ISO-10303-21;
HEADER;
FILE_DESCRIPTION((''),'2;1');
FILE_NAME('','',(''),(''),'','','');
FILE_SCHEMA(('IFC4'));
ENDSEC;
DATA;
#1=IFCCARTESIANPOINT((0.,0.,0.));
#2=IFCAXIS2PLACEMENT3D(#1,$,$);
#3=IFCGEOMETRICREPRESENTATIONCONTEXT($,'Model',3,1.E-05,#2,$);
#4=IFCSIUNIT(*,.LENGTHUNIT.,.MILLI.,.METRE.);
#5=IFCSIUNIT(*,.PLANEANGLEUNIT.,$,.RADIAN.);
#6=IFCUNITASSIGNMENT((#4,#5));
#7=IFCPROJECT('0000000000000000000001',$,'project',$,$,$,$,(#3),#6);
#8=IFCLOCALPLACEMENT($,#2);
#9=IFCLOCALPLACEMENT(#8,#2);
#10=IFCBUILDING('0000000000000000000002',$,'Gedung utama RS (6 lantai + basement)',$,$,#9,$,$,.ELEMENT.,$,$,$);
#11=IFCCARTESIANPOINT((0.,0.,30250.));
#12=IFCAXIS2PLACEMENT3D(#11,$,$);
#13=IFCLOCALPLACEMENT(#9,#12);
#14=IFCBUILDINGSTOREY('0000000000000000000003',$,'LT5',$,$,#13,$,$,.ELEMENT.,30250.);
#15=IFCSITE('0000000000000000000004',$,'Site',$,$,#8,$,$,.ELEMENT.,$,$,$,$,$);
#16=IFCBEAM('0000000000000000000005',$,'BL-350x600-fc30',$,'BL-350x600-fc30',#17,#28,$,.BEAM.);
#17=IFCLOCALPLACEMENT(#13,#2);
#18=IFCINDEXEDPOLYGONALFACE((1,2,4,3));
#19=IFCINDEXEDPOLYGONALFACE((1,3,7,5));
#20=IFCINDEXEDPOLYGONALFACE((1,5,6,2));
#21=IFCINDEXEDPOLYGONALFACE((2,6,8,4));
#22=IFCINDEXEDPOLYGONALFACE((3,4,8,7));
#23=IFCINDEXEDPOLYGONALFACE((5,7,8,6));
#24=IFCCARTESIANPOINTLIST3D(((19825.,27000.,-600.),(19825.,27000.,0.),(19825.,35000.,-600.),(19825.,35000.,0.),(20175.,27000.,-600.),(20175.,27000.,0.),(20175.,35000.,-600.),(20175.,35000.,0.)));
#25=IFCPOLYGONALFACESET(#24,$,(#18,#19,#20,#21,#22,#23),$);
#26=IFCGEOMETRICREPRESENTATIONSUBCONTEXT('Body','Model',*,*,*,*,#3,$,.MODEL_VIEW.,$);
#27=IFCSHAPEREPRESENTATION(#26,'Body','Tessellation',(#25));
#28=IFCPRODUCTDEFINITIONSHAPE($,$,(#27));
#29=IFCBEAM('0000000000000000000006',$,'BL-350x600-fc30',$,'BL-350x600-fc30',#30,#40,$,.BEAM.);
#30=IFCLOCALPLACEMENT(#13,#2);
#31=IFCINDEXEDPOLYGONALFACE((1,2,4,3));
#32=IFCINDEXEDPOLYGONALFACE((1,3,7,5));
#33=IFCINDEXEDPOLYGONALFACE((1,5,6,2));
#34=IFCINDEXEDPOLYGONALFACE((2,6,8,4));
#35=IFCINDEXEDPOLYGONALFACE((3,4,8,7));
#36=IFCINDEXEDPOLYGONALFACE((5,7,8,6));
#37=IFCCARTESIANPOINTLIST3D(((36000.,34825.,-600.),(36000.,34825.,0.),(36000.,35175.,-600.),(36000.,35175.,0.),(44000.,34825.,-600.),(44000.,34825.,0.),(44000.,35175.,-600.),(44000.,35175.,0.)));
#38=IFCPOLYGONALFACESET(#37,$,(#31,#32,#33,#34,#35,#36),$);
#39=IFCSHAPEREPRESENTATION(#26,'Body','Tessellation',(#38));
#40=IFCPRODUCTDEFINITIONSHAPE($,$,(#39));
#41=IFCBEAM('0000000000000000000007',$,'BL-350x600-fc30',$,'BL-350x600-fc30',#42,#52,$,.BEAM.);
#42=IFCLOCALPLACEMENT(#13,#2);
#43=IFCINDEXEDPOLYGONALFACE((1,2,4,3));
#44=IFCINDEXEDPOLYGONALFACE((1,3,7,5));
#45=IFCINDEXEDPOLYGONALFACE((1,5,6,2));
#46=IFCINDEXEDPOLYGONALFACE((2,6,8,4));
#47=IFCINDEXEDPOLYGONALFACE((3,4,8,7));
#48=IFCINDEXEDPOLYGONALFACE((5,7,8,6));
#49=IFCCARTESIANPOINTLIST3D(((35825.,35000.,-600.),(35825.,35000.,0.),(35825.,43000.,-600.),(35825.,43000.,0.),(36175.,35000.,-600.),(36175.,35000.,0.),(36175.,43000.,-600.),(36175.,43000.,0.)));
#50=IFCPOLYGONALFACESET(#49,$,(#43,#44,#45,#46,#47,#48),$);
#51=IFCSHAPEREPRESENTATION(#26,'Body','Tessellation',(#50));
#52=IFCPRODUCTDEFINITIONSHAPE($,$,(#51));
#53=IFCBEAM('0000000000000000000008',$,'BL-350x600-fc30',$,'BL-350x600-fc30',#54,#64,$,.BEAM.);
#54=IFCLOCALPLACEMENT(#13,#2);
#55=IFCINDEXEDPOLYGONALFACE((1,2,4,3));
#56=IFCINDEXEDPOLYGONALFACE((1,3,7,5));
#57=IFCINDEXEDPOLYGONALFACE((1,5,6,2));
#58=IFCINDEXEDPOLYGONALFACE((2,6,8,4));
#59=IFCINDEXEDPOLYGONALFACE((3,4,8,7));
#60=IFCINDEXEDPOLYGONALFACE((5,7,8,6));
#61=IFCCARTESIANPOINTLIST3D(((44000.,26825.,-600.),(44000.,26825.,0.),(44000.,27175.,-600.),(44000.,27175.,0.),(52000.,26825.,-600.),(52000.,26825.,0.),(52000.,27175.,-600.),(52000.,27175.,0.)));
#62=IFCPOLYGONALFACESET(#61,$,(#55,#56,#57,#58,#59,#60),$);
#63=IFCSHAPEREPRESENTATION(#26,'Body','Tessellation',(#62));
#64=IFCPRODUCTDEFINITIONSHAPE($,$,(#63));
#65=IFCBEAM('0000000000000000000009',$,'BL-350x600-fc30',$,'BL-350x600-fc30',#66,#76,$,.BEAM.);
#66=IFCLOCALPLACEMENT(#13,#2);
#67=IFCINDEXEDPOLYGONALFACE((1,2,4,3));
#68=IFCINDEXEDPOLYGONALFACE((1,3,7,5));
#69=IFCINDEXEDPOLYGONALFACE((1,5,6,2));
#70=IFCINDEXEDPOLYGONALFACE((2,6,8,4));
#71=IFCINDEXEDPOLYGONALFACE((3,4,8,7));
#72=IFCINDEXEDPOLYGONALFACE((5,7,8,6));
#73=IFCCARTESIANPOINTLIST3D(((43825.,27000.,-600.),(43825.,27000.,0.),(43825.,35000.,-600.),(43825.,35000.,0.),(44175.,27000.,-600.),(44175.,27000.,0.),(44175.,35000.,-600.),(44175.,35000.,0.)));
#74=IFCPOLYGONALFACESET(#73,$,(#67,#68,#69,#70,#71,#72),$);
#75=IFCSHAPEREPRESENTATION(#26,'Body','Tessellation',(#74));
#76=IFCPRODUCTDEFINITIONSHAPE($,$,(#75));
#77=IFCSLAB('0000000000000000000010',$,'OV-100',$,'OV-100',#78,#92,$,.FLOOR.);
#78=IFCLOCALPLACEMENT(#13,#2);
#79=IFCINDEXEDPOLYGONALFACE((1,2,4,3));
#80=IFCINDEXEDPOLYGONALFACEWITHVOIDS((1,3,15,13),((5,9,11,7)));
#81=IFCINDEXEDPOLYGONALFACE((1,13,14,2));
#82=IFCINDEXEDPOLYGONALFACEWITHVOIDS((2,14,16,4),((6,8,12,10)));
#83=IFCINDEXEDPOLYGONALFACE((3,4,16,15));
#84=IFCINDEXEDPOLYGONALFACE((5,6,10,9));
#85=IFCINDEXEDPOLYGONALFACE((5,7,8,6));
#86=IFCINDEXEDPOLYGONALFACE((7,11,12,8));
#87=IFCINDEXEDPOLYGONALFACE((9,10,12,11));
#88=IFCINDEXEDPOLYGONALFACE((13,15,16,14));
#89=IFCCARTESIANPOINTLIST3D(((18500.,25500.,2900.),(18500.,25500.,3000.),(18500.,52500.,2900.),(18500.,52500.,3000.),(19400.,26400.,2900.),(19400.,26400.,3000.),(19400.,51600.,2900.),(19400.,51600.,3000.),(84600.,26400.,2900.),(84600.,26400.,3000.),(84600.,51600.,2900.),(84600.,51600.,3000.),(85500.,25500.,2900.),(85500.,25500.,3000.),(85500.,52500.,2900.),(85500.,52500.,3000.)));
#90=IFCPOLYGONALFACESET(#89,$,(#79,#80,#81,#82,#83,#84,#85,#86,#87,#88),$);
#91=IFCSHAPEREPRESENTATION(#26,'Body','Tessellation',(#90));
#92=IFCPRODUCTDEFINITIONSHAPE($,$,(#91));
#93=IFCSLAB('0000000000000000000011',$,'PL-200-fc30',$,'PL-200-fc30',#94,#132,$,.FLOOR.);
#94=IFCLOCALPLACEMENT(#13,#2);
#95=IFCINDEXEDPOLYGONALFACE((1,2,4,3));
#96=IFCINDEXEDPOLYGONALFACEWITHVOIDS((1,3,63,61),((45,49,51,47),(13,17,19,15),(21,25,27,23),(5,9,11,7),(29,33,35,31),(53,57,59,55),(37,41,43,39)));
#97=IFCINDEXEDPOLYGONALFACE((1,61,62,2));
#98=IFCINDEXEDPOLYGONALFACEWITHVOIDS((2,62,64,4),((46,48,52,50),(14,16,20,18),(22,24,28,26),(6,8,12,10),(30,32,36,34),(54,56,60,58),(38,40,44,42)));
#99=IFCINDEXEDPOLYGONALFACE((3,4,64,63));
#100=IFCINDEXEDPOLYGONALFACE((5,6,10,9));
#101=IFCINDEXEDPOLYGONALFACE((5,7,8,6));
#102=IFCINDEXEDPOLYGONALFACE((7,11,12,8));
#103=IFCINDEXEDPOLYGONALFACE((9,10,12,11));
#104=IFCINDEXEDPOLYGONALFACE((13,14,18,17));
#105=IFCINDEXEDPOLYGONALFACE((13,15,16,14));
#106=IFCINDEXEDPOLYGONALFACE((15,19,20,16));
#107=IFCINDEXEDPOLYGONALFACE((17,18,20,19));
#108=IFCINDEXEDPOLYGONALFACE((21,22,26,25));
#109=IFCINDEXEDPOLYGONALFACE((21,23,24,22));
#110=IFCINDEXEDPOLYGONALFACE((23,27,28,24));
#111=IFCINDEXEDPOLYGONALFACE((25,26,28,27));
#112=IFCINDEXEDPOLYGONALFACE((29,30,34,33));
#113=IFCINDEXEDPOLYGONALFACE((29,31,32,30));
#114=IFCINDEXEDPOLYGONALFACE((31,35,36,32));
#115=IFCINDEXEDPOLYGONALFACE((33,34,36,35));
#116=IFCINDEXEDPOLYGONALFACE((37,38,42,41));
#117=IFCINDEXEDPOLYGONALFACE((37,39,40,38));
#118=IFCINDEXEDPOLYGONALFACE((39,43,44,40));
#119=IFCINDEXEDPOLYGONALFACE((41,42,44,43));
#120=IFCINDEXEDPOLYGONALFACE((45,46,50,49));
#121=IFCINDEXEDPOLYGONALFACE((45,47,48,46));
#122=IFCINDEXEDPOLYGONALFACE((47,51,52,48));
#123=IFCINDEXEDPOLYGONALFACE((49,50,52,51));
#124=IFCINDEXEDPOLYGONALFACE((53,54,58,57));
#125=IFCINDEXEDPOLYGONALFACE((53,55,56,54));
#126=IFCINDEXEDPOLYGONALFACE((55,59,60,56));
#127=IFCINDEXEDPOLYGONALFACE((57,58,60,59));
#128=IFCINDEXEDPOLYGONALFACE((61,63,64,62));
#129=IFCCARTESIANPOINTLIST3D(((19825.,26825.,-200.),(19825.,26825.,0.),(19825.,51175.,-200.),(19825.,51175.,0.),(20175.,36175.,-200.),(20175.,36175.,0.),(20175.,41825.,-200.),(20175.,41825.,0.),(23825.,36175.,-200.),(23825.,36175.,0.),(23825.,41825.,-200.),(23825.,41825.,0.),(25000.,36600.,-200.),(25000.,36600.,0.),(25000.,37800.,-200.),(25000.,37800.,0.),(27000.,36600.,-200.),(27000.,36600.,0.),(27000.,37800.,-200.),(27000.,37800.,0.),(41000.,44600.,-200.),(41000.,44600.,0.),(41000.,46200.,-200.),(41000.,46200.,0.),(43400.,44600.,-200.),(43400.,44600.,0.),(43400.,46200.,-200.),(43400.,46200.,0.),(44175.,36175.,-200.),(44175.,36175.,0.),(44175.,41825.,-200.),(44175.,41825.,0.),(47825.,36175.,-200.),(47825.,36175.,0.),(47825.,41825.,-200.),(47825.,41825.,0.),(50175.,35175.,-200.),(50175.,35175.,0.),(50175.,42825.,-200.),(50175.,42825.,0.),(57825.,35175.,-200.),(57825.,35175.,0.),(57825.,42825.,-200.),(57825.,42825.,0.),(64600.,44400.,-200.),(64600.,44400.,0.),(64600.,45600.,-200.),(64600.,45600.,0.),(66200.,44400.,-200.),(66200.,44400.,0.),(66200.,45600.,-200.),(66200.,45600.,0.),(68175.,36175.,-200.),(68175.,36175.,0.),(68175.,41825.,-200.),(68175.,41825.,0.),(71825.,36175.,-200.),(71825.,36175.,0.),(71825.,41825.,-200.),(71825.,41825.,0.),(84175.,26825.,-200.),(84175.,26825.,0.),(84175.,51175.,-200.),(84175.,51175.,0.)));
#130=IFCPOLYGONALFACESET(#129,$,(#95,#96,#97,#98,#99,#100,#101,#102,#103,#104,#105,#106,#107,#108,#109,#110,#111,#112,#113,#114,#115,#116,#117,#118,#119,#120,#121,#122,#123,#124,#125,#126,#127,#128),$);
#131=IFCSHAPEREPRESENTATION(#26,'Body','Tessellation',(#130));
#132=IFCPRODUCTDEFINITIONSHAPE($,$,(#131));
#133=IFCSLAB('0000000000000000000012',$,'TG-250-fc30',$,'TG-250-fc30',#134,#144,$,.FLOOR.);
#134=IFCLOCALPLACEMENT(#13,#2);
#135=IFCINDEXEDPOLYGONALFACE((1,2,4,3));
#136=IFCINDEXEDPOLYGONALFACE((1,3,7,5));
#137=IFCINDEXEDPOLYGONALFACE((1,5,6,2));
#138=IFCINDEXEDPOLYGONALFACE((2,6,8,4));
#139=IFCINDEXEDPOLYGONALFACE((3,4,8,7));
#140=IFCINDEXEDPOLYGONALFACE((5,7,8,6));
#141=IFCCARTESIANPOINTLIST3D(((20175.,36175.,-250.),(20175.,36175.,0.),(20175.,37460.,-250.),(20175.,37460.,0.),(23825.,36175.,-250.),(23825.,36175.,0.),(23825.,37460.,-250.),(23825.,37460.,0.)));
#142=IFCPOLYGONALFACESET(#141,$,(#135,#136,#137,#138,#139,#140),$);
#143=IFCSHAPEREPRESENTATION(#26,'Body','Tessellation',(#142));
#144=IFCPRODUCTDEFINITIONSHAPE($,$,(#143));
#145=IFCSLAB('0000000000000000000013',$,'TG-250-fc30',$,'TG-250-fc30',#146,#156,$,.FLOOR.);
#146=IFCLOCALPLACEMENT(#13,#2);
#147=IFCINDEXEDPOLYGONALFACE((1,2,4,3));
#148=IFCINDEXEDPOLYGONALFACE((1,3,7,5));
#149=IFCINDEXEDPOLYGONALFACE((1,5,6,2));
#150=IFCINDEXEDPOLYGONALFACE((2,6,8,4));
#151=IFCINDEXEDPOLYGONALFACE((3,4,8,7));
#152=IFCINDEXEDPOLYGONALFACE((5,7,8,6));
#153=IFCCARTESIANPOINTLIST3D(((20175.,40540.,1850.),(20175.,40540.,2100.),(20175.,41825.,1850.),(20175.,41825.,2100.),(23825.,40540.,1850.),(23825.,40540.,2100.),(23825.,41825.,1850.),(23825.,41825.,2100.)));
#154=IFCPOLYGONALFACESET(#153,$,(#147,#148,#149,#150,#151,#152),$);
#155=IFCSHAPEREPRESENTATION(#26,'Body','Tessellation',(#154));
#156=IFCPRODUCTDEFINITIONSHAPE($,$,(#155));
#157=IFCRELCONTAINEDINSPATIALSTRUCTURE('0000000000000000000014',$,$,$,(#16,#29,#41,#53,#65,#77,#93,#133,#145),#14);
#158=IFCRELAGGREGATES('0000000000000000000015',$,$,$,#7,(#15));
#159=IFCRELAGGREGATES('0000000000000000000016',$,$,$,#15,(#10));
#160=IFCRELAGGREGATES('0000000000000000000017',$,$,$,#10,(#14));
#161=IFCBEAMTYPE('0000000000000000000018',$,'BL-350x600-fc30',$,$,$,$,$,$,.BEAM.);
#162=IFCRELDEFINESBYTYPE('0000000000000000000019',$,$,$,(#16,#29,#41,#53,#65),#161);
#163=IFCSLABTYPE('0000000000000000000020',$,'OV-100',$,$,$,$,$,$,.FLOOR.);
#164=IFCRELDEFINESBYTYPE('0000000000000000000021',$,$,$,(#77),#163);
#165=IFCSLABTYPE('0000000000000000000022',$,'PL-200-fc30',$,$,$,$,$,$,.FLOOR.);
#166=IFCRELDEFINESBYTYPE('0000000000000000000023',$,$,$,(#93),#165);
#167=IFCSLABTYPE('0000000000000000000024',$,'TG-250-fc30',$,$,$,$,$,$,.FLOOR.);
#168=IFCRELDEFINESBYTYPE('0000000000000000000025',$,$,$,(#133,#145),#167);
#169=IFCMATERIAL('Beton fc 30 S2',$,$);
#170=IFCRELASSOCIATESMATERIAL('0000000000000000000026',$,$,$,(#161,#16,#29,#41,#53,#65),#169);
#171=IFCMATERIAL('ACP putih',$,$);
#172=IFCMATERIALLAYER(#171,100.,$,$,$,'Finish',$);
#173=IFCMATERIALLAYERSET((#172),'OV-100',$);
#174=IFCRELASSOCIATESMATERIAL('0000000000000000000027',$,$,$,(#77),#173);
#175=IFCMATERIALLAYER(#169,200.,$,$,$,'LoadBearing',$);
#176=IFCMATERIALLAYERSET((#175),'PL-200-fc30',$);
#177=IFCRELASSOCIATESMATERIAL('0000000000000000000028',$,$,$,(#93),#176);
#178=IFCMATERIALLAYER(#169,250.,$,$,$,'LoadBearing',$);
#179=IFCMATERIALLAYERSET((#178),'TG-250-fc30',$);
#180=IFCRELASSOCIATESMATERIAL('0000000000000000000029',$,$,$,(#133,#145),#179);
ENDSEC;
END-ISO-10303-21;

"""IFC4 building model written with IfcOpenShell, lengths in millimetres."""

from ifc_helpers import new_model, si_unit, frame, origin, origin_2d, place, context, subcontext, project, spatial, polyline, rectangle, outline, extrude, material, layer, layer_set, layer_usage, material_profile, profile_set, profile_usage, type_object, element, save


model = new_model("IFC4")

# Units and contexts
model_context = context("Model", 3, precision=1e-05, world=origin())
body_context = subcontext(model_context, "Body", "Model", "MODEL_VIEW")
ifc_project = project(units=[si_unit("LENGTHUNIT", "METRE", prefix="MILLI"), si_unit("PLANEANGLEUNIT", "RADIAN")], contexts=[model_context])

# Site, building, storey
site_placement = place(None, origin())
site = spatial("IfcSite", under=ifc_project, at=site_placement, Name="Site", CompositionType="ELEMENT")
building_placement = place(site_placement, origin())
building = spatial("IfcBuilding", under=site, at=building_placement, Name="Gedung utama RS (6 lantai + basement)", CompositionType="ELEMENT")
storey_placement = place(building_placement, frame((0.0, 0.0, 30250.0)))
storey = spatial("IfcBuildingStorey", under=building, at=storey_placement, Name="LT5", CompositionType="ELEMENT", Elevation=30250.0)

# Beams
ifc_material_1 = material(Name="Beton fc 30 S2")
ifc_material_profile_1 = material_profile(ifc_material_1, rectangle(XDim=350.0, YDim=600.0, at=origin_2d()), Name="BL-350x600-fc30")
ifc_profile_set_1 = profile_set([ifc_material_profile_1], Name="BL-350x600-fc30")
ifc_profile_usage_1 = profile_usage(ifc_profile_set_1, cardinal=8)
beam_type = type_object("IfcBeamType", Name="BL-350x600-fc30", PredefinedType="BEAM", material=ifc_profile_set_1)
beam_1_placement = place(storey_placement, frame((20000.0, 27000.0, -300.0)))
element("IfcBeam", 1, at=beam_1_placement, inside=storey, type_object=beam_type, material=ifc_profile_usage_1, Name="BL-350x600-fc30", ObjectType="BL-350x600-fc30", PredefinedType="BEAM", context=body_context, shape_type="SweptSolid", body=[
    extrude(rectangle(XDim=350.0, YDim=600.0, at=origin_2d()), frame((0.0, 0.0, 0.0), z_axis=(0.0, 1.0, 0.0), x_axis=(-1.0, 0.0, 0.0)), (0.0, 0.0, 1.0), 8000.0),
])
beam_2_placement = place(storey_placement, frame((36000.0, 35000.0, -300.0)))
element("IfcBeam", 2, at=beam_2_placement, inside=storey, type_object=beam_type, material=ifc_profile_usage_1, Name="BL-350x600-fc30", ObjectType="BL-350x600-fc30", PredefinedType="BEAM", context=body_context, shape_type="SweptSolid", body=[
    extrude(rectangle(XDim=350.0, YDim=600.0, at=origin_2d()), frame((0.0, 0.0, 0.0), z_axis=(1.0, 0.0, 0.0), x_axis=(0.0, 1.0, 0.0)), (0.0, 0.0, 1.0), 8000.0),
])
beam_3_placement = place(storey_placement, frame((36000.0, 35000.0, -300.0)))
element("IfcBeam", 3, at=beam_3_placement, inside=storey, type_object=beam_type, material=ifc_profile_usage_1, Name="BL-350x600-fc30", ObjectType="BL-350x600-fc30", PredefinedType="BEAM", context=body_context, shape_type="SweptSolid", body=[
    extrude(rectangle(XDim=350.0, YDim=600.0, at=origin_2d()), frame((0.0, 0.0, 0.0), z_axis=(0.0, 1.0, 0.0), x_axis=(-1.0, 0.0, 0.0)), (0.0, 0.0, 1.0), 8000.0),
])
beam_4_placement = place(storey_placement, frame((44000.0, 27000.0, -300.0)))
element("IfcBeam", 4, at=beam_4_placement, inside=storey, type_object=beam_type, material=ifc_profile_usage_1, Name="BL-350x600-fc30", ObjectType="BL-350x600-fc30", PredefinedType="BEAM", context=body_context, shape_type="SweptSolid", body=[
    extrude(rectangle(XDim=350.0, YDim=600.0, at=origin_2d()), frame((0.0, 0.0, 0.0), z_axis=(1.0, 0.0, 0.0), x_axis=(0.0, 1.0, 0.0)), (0.0, 0.0, 1.0), 8000.0),
])
beam_5_placement = place(storey_placement, frame((44000.0, 27000.0, -300.0)))
element("IfcBeam", 5, at=beam_5_placement, inside=storey, type_object=beam_type, material=ifc_profile_usage_1, Name="BL-350x600-fc30", ObjectType="BL-350x600-fc30", PredefinedType="BEAM", context=body_context, shape_type="SweptSolid", body=[
    extrude(rectangle(XDim=350.0, YDim=600.0, at=origin_2d()), frame((0.0, 0.0, 0.0), z_axis=(0.0, 1.0, 0.0), x_axis=(-1.0, 0.0, 0.0)), (0.0, 0.0, 1.0), 8000.0),
])

# Slab
ifc_material_2 = material(Name="ACP putih")
ifc_layer_1 = layer(ifc_material_2, 100.0, Category="Finish")
ifc_layer_set_1 = layer_set([ifc_layer_1], Name="OV-100")
ifc_layer_usage_1 = layer_usage(ifc_layer_set_1, "AXIS3", "NEGATIVE", 3000.0)
slab_type_1 = type_object("IfcSlabType", Name="OV-100", PredefinedType="FLOOR")
slab_1_placement = place(storey_placement, origin())
element("IfcSlab", 6, at=slab_1_placement, inside=storey, type_object=slab_type_1, material=ifc_layer_usage_1, Name="OV-100", ObjectType="OV-100", PredefinedType="FLOOR", context=body_context, shape_type="SweptSolid", body=[
    extrude(outline(polyline([(85500.0, 52500.0), (18500.0, 52500.0), (18500.0, 25500.0), (85500.0, 25500.0), (85500.0, 52500.0)]), holes=[polyline([(84600.0, 26400.0), (19400.0, 26400.0), (19400.0, 51600.0), (84600.0, 51600.0), (84600.0, 26400.0)])]), frame((0.0, 0.0, 2900.0)), (0.0, 0.0, 1.0), 100.0),
])

# Slab, openings
ifc_layer_2 = layer(ifc_material_1, 200.0, Category="LoadBearing")
ifc_layer_set_2 = layer_set([ifc_layer_2], Name="PL-200-fc30")
ifc_layer_usage_2 = layer_usage(ifc_layer_set_2, "AXIS3", "NEGATIVE", 0.0)
slab_type_2 = type_object("IfcSlabType", Name="PL-200-fc30", PredefinedType="FLOOR")
slab_2_placement = place(storey_placement, origin())
slab_2 = element("IfcSlab", 7, at=slab_2_placement, inside=storey, type_object=slab_type_2, material=ifc_layer_usage_2, Name="PL-200-fc30", ObjectType="PL-200-fc30", PredefinedType="FLOOR", context=body_context, shape_type="SweptSolid", body=[
    extrude(outline(polyline([(84175.0, 51175.0), (19825.0, 51175.0), (19825.0, 26825.0), (84175.0, 26825.0), (84175.0, 51175.0)]), holes=[polyline([(23825.0, 36175.0), (23825.0, 41825.0), (20175.0, 41825.0), (20175.0, 36175.0), (23825.0, 36175.0)]), polyline([(47825.0, 36175.0), (47825.0, 41825.0), (44175.0, 41825.0), (44175.0, 36175.0), (47825.0, 36175.0)]), polyline([(71825.0, 36175.0), (71825.0, 41825.0), (68175.0, 41825.0), (68175.0, 36175.0), (71825.0, 36175.0)])]), frame((0.0, 0.0, -200.0)), (0.0, 0.0, 1.0), 200.0),
])
opening_1_placement = place(slab_2_placement, frame((0.0, 0.0, -17300.0)))
element("IfcOpeningElement", 8, at=opening_1_placement, cuts=slab_2, PredefinedType="OPENING", context=body_context, shape_type="SweptSolid", body=[
    extrude(outline(polyline([(27000.0, 36600.0), (27000.0, 37800.0), (25000.0, 37800.0), (25000.0, 36600.0), (27000.0, 36600.0)])), origin(), (0.0, 0.0, 1.0), 25800.0),
])
opening_2_placement = place(slab_2_placement, frame((0.0, 0.0, -17300.0)))
element("IfcOpeningElement", 9, at=opening_2_placement, cuts=slab_2, PredefinedType="OPENING", context=body_context, shape_type="SweptSolid", body=[
    extrude(outline(polyline([(43400.0, 44600.0), (43400.0, 46200.0), (41000.0, 46200.0), (41000.0, 44600.0), (43400.0, 44600.0)])), origin(), (0.0, 0.0, 1.0), 25800.0),
])
opening_3_placement = place(slab_2_placement, frame((0.0, 0.0, -17300.0)))
element("IfcOpeningElement", 10, at=opening_3_placement, cuts=slab_2, PredefinedType="OPENING", context=body_context, shape_type="SweptSolid", body=[
    extrude(outline(polyline([(66200.0, 44400.0), (66200.0, 45600.0), (64600.0, 45600.0), (64600.0, 44400.0), (66200.0, 44400.0)])), origin(), (0.0, 0.0, 1.0), 25800.0),
])
opening_4_placement = place(slab_2_placement, frame((0.0, 0.0, -17300.0)))
element("IfcOpeningElement", 11, at=opening_4_placement, cuts=slab_2, PredefinedType="OPENING", context=body_context, shape_type="SweptSolid", body=[
    extrude(outline(polyline([(57825.0, 35175.0), (57825.0, 42825.0), (50175.0, 42825.0), (50175.0, 35175.0), (57825.0, 35175.0)])), origin(), (0.0, 0.0, 1.0), 21600.0),
])

# Slabs
ifc_layer_3 = layer(ifc_material_1, 250.0, Category="LoadBearing")
ifc_layer_set_3 = layer_set([ifc_layer_3], Name="TG-250-fc30")
ifc_layer_usage_3 = layer_usage(ifc_layer_set_3, "AXIS3", "NEGATIVE", 0.0)
slab_type_3 = type_object("IfcSlabType", Name="TG-250-fc30", PredefinedType="FLOOR")
slab_3_placement = place(storey_placement, origin())
element("IfcSlab", 12, at=slab_3_placement, inside=storey, type_object=slab_type_3, material=ifc_layer_usage_3, Name="TG-250-fc30", ObjectType="TG-250-fc30", PredefinedType="FLOOR", context=body_context, shape_type="SweptSolid", body=[
    extrude(outline(polyline([(23825.0, 36175.0), (23825.0, 37460.0), (20175.0, 37460.0), (20175.0, 36175.0), (23825.0, 36175.0)])), frame((0.0, 0.0, -250.0)), (0.0, 0.0, 1.0), 250.0),
])
ifc_layer_usage_4 = layer_usage(ifc_layer_set_3, "AXIS3", "NEGATIVE", 2100.0)
slab_4_placement = place(storey_placement, origin())
element("IfcSlab", 13, at=slab_4_placement, inside=storey, type_object=slab_type_3, material=ifc_layer_usage_4, Name="TG-250-fc30", ObjectType="TG-250-fc30", PredefinedType="FLOOR", context=body_context, shape_type="SweptSolid", body=[
    extrude(outline(polyline([(23825.0, 40540.0), (23825.0, 41825.0), (20175.0, 41825.0), (20175.0, 40540.0), (23825.0, 40540.0)])), frame((0.0, 0.0, 1850.0)), (0.0, 0.0, 1.0), 250.0),
])

save(model, "model.ifc")
